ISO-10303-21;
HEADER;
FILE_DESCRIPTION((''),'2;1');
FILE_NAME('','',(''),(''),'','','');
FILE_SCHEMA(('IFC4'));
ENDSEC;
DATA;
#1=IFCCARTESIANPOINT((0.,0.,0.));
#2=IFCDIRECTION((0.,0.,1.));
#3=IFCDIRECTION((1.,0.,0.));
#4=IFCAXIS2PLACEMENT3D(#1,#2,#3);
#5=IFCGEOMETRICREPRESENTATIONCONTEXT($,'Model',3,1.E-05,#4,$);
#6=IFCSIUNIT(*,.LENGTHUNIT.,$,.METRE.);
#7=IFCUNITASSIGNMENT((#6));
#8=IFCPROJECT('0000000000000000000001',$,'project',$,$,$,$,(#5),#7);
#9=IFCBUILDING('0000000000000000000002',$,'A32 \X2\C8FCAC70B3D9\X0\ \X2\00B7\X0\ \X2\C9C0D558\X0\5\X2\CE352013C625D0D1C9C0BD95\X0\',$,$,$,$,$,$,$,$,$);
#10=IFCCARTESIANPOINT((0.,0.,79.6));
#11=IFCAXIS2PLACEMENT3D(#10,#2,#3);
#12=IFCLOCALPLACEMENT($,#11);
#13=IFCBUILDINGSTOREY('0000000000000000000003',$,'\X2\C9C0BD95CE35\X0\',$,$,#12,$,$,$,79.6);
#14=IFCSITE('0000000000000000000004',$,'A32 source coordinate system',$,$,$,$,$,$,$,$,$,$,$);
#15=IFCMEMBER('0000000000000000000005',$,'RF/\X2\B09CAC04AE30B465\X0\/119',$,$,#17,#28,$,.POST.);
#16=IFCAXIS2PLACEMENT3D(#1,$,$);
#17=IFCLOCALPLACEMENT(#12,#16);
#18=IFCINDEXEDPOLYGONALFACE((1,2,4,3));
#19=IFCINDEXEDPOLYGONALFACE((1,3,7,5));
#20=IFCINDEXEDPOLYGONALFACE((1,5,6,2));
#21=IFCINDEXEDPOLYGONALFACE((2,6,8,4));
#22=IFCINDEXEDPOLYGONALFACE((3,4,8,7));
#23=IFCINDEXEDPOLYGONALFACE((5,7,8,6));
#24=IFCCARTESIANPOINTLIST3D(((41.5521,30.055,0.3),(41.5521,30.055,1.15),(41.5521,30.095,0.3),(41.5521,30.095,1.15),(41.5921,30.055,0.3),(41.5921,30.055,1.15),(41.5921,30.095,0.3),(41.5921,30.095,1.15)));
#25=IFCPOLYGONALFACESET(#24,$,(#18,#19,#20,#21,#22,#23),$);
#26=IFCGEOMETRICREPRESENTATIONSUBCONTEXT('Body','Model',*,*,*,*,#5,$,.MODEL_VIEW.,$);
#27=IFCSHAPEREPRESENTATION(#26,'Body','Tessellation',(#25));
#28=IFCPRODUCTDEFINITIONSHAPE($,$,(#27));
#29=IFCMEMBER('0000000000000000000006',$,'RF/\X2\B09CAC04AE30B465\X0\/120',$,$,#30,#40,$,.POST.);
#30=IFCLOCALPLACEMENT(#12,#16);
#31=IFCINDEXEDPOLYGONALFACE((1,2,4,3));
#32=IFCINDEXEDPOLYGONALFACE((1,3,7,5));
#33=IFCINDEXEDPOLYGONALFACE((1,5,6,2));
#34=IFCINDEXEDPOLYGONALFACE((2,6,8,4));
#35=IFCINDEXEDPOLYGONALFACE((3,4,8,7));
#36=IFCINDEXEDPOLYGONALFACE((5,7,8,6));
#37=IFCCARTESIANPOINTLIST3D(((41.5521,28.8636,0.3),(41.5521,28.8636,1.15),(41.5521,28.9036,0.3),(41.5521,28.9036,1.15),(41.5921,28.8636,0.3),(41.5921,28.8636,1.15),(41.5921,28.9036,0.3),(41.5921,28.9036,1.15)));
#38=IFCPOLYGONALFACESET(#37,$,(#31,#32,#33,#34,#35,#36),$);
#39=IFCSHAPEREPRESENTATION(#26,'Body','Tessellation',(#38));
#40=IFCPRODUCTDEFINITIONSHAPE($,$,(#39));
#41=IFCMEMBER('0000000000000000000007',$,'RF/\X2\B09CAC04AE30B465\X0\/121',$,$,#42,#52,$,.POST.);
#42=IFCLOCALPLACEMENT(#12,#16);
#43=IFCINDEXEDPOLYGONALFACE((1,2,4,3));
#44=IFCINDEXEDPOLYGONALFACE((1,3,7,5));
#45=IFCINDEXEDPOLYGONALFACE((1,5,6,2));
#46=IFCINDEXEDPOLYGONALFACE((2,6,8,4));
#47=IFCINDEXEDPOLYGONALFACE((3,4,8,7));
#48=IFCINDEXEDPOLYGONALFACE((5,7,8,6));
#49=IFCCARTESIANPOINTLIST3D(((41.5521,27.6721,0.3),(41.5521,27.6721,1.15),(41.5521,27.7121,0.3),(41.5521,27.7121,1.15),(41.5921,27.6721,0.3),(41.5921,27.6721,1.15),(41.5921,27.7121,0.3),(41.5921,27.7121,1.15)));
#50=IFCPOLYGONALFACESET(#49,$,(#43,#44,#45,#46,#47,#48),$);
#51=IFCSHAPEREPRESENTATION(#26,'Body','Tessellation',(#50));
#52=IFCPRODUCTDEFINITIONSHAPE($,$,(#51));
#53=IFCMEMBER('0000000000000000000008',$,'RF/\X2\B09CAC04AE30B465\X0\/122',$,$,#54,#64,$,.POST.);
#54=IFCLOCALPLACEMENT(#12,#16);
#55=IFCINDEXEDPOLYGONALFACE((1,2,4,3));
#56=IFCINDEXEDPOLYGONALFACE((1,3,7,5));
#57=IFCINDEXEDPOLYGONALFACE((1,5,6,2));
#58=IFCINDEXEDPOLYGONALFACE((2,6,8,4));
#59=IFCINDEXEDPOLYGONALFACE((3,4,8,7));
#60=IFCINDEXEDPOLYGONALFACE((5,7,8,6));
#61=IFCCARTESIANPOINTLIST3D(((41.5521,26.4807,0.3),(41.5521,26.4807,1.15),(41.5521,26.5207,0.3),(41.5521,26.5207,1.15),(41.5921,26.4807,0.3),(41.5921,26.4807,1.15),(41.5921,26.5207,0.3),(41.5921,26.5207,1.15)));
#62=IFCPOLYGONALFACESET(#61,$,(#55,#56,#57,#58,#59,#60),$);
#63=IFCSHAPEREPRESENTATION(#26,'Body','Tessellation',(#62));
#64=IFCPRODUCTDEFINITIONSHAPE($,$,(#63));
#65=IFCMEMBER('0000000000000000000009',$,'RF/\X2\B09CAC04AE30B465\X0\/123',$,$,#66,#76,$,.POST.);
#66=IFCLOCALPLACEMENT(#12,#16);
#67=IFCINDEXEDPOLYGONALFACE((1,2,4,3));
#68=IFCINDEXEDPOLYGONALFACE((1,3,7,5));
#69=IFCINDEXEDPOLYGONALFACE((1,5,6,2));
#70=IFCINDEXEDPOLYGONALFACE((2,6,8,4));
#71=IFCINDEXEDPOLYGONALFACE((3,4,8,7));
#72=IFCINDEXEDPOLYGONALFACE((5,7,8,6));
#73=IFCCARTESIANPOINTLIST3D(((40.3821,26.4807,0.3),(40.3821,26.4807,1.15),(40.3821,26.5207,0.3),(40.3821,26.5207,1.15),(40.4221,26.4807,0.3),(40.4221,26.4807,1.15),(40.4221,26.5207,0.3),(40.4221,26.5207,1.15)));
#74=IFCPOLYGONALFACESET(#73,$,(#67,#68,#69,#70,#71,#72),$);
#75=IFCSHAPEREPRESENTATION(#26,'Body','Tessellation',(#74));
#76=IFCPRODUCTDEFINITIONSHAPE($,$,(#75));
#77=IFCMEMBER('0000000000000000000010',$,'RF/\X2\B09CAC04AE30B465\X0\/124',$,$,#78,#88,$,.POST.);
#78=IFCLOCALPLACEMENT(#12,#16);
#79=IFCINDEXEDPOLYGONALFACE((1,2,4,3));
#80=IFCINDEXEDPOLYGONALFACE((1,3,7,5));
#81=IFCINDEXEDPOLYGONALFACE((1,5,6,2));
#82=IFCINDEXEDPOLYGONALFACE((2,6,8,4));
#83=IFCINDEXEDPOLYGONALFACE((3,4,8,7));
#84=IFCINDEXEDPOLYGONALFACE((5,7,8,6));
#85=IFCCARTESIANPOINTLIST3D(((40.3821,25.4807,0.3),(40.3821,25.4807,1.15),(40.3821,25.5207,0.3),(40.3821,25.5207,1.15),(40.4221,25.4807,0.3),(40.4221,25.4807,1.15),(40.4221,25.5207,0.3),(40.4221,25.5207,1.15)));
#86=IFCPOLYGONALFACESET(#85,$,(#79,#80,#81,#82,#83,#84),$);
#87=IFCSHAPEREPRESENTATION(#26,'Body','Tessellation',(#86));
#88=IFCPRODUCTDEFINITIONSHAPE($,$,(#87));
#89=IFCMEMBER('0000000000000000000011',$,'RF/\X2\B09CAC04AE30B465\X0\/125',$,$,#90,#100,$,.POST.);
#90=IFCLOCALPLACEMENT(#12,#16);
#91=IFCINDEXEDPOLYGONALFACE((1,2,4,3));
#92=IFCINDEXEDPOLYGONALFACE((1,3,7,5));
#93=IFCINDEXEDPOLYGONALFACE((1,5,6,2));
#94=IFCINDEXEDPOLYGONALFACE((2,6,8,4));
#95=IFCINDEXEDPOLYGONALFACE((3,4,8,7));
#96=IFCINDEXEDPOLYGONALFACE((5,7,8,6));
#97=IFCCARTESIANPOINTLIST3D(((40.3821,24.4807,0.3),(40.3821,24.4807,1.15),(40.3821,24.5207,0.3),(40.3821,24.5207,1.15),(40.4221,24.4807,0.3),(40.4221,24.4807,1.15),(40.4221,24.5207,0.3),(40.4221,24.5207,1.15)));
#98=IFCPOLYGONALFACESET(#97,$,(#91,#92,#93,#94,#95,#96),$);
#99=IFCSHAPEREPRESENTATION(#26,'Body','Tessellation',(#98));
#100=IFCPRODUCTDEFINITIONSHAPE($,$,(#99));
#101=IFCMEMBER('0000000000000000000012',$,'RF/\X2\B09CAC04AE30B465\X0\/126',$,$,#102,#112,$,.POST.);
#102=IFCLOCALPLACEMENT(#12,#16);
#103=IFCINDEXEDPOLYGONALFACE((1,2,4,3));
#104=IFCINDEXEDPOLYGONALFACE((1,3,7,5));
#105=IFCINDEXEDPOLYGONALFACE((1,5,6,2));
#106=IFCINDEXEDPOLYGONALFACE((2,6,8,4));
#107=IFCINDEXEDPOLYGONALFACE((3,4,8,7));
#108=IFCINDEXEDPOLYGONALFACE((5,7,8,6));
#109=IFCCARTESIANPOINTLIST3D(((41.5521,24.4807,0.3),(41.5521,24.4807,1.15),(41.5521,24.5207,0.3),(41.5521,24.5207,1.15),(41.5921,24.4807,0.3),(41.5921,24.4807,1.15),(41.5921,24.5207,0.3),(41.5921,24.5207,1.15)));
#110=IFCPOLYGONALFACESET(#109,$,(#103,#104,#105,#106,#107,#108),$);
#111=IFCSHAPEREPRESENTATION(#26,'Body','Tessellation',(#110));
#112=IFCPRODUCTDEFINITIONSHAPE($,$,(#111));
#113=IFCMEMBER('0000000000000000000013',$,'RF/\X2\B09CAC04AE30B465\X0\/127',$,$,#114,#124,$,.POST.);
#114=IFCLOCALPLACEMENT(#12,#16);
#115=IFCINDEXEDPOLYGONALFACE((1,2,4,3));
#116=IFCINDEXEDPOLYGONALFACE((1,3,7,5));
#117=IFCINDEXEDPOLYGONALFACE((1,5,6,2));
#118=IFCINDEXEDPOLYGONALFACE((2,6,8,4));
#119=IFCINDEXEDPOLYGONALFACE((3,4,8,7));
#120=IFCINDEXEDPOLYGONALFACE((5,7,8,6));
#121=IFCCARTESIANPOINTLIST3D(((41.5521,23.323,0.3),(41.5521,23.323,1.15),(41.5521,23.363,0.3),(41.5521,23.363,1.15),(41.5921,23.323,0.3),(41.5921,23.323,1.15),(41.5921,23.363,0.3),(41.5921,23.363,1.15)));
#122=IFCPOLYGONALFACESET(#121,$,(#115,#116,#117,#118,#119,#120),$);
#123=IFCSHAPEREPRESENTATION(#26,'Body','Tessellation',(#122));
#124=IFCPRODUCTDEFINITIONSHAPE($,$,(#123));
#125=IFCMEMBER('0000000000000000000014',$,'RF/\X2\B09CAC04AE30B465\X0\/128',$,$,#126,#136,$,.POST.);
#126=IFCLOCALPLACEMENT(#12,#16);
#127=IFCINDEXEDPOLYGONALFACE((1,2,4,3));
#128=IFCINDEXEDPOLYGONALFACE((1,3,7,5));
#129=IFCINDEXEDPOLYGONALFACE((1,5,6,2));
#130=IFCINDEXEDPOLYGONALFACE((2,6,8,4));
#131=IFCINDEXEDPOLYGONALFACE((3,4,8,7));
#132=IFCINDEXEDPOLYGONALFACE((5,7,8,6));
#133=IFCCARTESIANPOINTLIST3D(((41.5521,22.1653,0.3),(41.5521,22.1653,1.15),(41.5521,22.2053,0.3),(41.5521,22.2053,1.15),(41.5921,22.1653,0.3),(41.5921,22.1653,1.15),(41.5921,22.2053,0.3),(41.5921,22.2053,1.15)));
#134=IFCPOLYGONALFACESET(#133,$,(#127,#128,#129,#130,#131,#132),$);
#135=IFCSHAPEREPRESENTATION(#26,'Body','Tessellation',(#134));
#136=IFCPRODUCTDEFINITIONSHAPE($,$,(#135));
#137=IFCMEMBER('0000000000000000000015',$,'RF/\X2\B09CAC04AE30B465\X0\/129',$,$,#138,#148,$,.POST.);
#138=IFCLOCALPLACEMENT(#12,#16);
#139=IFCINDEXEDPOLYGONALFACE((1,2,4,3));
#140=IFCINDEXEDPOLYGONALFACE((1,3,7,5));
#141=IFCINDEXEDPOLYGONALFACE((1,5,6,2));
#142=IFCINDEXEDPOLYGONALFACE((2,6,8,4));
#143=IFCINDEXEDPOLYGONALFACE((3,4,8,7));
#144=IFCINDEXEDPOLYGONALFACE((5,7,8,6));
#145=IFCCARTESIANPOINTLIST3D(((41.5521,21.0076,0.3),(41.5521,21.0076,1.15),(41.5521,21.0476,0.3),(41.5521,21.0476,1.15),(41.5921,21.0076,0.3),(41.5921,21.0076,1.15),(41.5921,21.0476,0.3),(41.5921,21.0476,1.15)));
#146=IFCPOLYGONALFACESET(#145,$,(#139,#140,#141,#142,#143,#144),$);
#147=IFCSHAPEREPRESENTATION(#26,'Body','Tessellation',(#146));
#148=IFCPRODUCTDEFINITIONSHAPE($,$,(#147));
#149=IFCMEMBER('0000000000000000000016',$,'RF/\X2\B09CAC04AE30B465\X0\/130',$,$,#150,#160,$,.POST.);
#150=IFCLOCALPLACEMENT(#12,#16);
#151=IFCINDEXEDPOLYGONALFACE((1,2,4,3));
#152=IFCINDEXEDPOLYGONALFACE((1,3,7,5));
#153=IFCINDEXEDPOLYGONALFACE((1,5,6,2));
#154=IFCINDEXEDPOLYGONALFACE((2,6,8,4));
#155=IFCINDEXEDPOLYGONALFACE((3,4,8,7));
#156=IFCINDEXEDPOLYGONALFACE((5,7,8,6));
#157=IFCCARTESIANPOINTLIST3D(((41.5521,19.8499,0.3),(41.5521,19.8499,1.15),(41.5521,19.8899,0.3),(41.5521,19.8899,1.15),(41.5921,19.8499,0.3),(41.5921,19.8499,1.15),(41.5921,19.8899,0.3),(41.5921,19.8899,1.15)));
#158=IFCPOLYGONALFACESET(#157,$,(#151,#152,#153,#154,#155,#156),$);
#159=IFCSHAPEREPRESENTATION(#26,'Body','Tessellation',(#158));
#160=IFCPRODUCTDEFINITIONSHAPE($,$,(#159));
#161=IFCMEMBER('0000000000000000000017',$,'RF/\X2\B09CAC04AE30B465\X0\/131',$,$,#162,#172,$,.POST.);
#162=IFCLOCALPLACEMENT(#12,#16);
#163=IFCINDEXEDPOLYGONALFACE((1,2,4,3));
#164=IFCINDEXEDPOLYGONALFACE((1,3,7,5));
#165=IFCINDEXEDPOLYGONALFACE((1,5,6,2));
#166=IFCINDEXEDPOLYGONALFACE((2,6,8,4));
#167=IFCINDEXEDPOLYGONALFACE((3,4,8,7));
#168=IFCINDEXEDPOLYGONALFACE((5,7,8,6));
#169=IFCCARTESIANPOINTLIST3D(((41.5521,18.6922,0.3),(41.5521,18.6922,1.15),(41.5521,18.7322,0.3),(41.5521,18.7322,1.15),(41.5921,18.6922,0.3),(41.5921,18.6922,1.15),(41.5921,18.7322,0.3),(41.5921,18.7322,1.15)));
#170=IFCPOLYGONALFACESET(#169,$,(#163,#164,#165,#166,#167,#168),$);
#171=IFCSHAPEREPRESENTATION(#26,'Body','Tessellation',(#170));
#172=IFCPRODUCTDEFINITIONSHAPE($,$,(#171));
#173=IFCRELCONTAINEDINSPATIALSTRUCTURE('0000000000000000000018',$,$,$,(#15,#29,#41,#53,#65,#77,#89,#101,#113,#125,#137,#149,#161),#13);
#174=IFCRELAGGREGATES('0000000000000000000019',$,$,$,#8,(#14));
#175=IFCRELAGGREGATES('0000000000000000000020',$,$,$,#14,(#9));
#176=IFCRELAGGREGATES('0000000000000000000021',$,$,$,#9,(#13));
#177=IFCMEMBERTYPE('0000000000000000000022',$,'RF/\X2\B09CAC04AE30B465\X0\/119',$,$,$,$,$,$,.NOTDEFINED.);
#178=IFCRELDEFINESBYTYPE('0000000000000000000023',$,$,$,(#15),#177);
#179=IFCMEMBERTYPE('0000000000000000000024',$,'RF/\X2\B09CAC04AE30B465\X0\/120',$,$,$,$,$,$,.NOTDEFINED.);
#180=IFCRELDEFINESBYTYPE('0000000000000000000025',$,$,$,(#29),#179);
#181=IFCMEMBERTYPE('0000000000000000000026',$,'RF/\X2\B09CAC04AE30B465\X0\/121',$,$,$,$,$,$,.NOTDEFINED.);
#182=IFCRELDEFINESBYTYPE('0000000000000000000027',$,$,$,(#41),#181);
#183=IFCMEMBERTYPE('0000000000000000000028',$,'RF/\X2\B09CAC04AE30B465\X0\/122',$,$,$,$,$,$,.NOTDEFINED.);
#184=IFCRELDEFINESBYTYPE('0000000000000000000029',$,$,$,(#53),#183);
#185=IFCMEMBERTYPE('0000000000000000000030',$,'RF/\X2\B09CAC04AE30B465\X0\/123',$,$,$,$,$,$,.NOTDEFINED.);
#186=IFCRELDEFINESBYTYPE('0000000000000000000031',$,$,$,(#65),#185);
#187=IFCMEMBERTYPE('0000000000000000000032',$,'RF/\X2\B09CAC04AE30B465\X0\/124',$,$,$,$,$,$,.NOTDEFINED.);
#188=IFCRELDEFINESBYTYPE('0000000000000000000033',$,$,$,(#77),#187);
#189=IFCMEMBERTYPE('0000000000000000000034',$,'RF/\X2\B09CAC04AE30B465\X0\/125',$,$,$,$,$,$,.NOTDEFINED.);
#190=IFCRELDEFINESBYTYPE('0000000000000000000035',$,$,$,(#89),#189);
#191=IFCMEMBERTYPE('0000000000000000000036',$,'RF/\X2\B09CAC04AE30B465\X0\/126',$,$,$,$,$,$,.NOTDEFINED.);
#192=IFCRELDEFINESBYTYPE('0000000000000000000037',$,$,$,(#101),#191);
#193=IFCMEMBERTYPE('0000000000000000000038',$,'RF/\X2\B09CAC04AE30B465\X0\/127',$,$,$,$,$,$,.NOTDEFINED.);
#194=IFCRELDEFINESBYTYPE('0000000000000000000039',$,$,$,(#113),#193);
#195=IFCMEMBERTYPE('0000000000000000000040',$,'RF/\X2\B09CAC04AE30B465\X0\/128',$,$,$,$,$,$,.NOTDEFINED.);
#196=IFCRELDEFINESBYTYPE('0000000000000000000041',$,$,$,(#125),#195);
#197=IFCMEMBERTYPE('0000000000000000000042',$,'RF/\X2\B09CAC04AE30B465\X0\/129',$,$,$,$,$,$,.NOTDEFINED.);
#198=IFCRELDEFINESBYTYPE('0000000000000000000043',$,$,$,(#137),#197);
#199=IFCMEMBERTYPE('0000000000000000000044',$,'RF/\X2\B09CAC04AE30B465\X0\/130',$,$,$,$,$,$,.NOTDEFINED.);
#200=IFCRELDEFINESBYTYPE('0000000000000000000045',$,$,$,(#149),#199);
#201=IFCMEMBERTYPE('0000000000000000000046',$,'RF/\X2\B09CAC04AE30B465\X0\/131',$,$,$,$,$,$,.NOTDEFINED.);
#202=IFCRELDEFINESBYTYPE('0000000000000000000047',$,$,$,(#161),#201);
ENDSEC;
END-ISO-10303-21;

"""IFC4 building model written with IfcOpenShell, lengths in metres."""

from ifc_helpers import new_model, si_unit, frame, origin, origin_with_axes, place, context, subcontext, project, spatial, polyline, outline, extrude, source, transform, mapped, type_object, type_shapes, element, save


model = new_model("IFC4")

# Units and contexts
model_context = context("Model", 3, precision=1e-05, world=origin_with_axes())
body_context = subcontext(model_context, "Body", "Model", "MODEL_VIEW")
ifc_project = project(units=[si_unit("LENGTHUNIT", "METRE")], contexts=[model_context])

# Site, building, storey
site = spatial("IfcSite", under=ifc_project, Name="A32 source coordinate system")
building = spatial("IfcBuilding", under=site, Name="A32 주거동 · 지하5층–옥탑지붕")
storey_placement = place(None, frame((0.0, 0.0, 79.6), z_axis=(0.0, 0.0, 1.0), x_axis=(1.0, 0.0, 0.0)))
storey = spatial("IfcBuildingStorey", under=building, at=storey_placement, Name="지붕층", Elevation=79.6)

# Members
member_type_1 = type_object("IfcMemberType", Name="RF/난간기둥/119", PredefinedType="NOTDEFINED")
shared_shape_1 = source(origin(), body_context, "Body", "SweptSolid", [
    extrude(outline(polyline([(41.5921, 30.055), (41.5521, 30.055), (41.5521, 30.095), (41.5921, 30.095), (41.5921, 30.055)])), frame((0.0, 0.0, 0.3)), (0.0, 0.0, 1.0), 0.85),
])
type_shapes(member_type_1, [shared_shape_1])
member_1_placement = place(storey_placement, origin_with_axes())
element("IfcMember", 1, at=member_1_placement, inside=storey, type_object=member_type_1, Name="RF/난간기둥/119", PredefinedType="POST", context=body_context, shape_type="MappedRepresentation", body=[
    mapped(shared_shape_1, transform((0.0, 0.0, 0.0), scale=1.0)),
])
member_type_2 = type_object("IfcMemberType", Name="RF/난간기둥/120", PredefinedType="NOTDEFINED")
shared_shape_2 = source(origin(), body_context, "Body", "SweptSolid", [
    extrude(outline(polyline([(41.5921, 28.8636), (41.5521, 28.8636), (41.5521, 28.9036), (41.5921, 28.9036), (41.5921, 28.8636)])), frame((0.0, 0.0, 0.3)), (0.0, 0.0, 1.0), 0.85),
])
type_shapes(member_type_2, [shared_shape_2])
member_2_placement = place(storey_placement, origin_with_axes())
element("IfcMember", 2, at=member_2_placement, inside=storey, type_object=member_type_2, Name="RF/난간기둥/120", PredefinedType="POST", context=body_context, shape_type="MappedRepresentation", body=[
    mapped(shared_shape_2, transform((0.0, 0.0, 0.0), scale=1.0)),
])
member_type_3 = type_object("IfcMemberType", Name="RF/난간기둥/121", PredefinedType="NOTDEFINED")
shared_shape_3 = source(origin(), body_context, "Body", "SweptSolid", [
    extrude(outline(polyline([(41.5921, 27.6721), (41.5521, 27.6721), (41.5521, 27.7121), (41.5921, 27.7121), (41.5921, 27.6721)])), frame((0.0, 0.0, 0.3)), (0.0, 0.0, 1.0), 0.85),
])
type_shapes(member_type_3, [shared_shape_3])
member_3_placement = place(storey_placement, origin_with_axes())
element("IfcMember", 3, at=member_3_placement, inside=storey, type_object=member_type_3, Name="RF/난간기둥/121", PredefinedType="POST", context=body_context, shape_type="MappedRepresentation", body=[
    mapped(shared_shape_3, transform((0.0, 0.0, 0.0), scale=1.0)),
])
member_type_4 = type_object("IfcMemberType", Name="RF/난간기둥/122", PredefinedType="NOTDEFINED")
shared_shape_4 = source(origin(), body_context, "Body", "SweptSolid", [
    extrude(outline(polyline([(41.5921, 26.4807), (41.5521, 26.4807), (41.5521, 26.5207), (41.5921, 26.5207), (41.5921, 26.4807)])), frame((0.0, 0.0, 0.3)), (0.0, 0.0, 1.0), 0.85),
])
type_shapes(member_type_4, [shared_shape_4])
member_4_placement = place(storey_placement, origin_with_axes())
element("IfcMember", 4, at=member_4_placement, inside=storey, type_object=member_type_4, Name="RF/난간기둥/122", PredefinedType="POST", context=body_context, shape_type="MappedRepresentation", body=[
    mapped(shared_shape_4, transform((0.0, 0.0, 0.0), scale=1.0)),
])
member_type_5 = type_object("IfcMemberType", Name="RF/난간기둥/123", PredefinedType="NOTDEFINED")
shared_shape_5 = source(origin(), body_context, "Body", "SweptSolid", [
    extrude(outline(polyline([(40.4221, 26.4807), (40.3821, 26.4807), (40.3821, 26.5207), (40.4221, 26.5207), (40.4221, 26.4807)])), frame((0.0, 0.0, 0.3)), (0.0, 0.0, 1.0), 0.85),
])
type_shapes(member_type_5, [shared_shape_5])
member_5_placement = place(storey_placement, origin_with_axes())
element("IfcMember", 5, at=member_5_placement, inside=storey, type_object=member_type_5, Name="RF/난간기둥/123", PredefinedType="POST", context=body_context, shape_type="MappedRepresentation", body=[
    mapped(shared_shape_5, transform((0.0, 0.0, 0.0), scale=1.0)),
])
member_type_6 = type_object("IfcMemberType", Name="RF/난간기둥/124", PredefinedType="NOTDEFINED")
shared_shape_6 = source(origin(), body_context, "Body", "SweptSolid", [
    extrude(outline(polyline([(40.4221, 25.4807), (40.3821, 25.4807), (40.3821, 25.5207), (40.4221, 25.5207), (40.4221, 25.4807)])), frame((0.0, 0.0, 0.3)), (0.0, 0.0, 1.0), 0.85),
])
type_shapes(member_type_6, [shared_shape_6])
member_6_placement = place(storey_placement, origin_with_axes())
element("IfcMember", 6, at=member_6_placement, inside=storey, type_object=member_type_6, Name="RF/난간기둥/124", PredefinedType="POST", context=body_context, shape_type="MappedRepresentation", body=[
    mapped(shared_shape_6, transform((0.0, 0.0, 0.0), scale=1.0)),
])
member_type_7 = type_object("IfcMemberType", Name="RF/난간기둥/125", PredefinedType="NOTDEFINED")
shared_shape_7 = source(origin(), body_context, "Body", "SweptSolid", [
    extrude(outline(polyline([(40.4221, 24.4807), (40.3821, 24.4807), (40.3821, 24.5207), (40.4221, 24.5207), (40.4221, 24.4807)])), frame((0.0, 0.0, 0.3)), (0.0, 0.0, 1.0), 0.85),
])
type_shapes(member_type_7, [shared_shape_7])
member_7_placement = place(storey_placement, origin_with_axes())
element("IfcMember", 7, at=member_7_placement, inside=storey, type_object=member_type_7, Name="RF/난간기둥/125", PredefinedType="POST", context=body_context, shape_type="MappedRepresentation", body=[
    mapped(shared_shape_7, transform((0.0, 0.0, 0.0), scale=1.0)),
])
member_type_8 = type_object("IfcMemberType", Name="RF/난간기둥/126", PredefinedType="NOTDEFINED")
shared_shape_8 = source(origin(), body_context, "Body", "SweptSolid", [
    extrude(outline(polyline([(41.5921, 24.4807), (41.5521, 24.4807), (41.5521, 24.5207), (41.5921, 24.5207), (41.5921, 24.4807)])), frame((0.0, 0.0, 0.3)), (0.0, 0.0, 1.0), 0.85),
])
type_shapes(member_type_8, [shared_shape_8])
member_8_placement = place(storey_placement, origin_with_axes())
element("IfcMember", 8, at=member_8_placement, inside=storey, type_object=member_type_8, Name="RF/난간기둥/126", PredefinedType="POST", context=body_context, shape_type="MappedRepresentation", body=[
    mapped(shared_shape_8, transform((0.0, 0.0, 0.0), scale=1.0)),
])
member_type_9 = type_object("IfcMemberType", Name="RF/난간기둥/127", PredefinedType="NOTDEFINED")
shared_shape_9 = source(origin(), body_context, "Body", "SweptSolid", [
    extrude(outline(polyline([(41.5921, 23.323), (41.5521, 23.323), (41.5521, 23.363), (41.5921, 23.363), (41.5921, 23.323)])), frame((0.0, 0.0, 0.3)), (0.0, 0.0, 1.0), 0.85),
])
type_shapes(member_type_9, [shared_shape_9])
member_9_placement = place(storey_placement, origin_with_axes())
element("IfcMember", 9, at=member_9_placement, inside=storey, type_object=member_type_9, Name="RF/난간기둥/127", PredefinedType="POST", context=body_context, shape_type="MappedRepresentation", body=[
    mapped(shared_shape_9, transform((0.0, 0.0, 0.0), scale=1.0)),
])
member_type_10 = type_object("IfcMemberType", Name="RF/난간기둥/128", PredefinedType="NOTDEFINED")
shared_shape_10 = source(origin(), body_context, "Body", "SweptSolid", [
    extrude(outline(polyline([(41.5921, 22.1653), (41.5521, 22.1653), (41.5521, 22.2053), (41.5921, 22.2053), (41.5921, 22.1653)])), frame((0.0, 0.0, 0.3)), (0.0, 0.0, 1.0), 0.85),
])
type_shapes(member_type_10, [shared_shape_10])
member_10_placement = place(storey_placement, origin_with_axes())
element("IfcMember", 10, at=member_10_placement, inside=storey, type_object=member_type_10, Name="RF/난간기둥/128", PredefinedType="POST", context=body_context, shape_type="MappedRepresentation", body=[
    mapped(shared_shape_10, transform((0.0, 0.0, 0.0), scale=1.0)),
])
member_type_11 = type_object("IfcMemberType", Name="RF/난간기둥/129", PredefinedType="NOTDEFINED")
shared_shape_11 = source(origin(), body_context, "Body", "SweptSolid", [
    extrude(outline(polyline([(41.5921, 21.0076), (41.5521, 21.0076), (41.5521, 21.0476), (41.5921, 21.0476), (41.5921, 21.0076)])), frame((0.0, 0.0, 0.3)), (0.0, 0.0, 1.0), 0.85),
])
type_shapes(member_type_11, [shared_shape_11])
member_11_placement = place(storey_placement, origin_with_axes())
element("IfcMember", 11, at=member_11_placement, inside=storey, type_object=member_type_11, Name="RF/난간기둥/129", PredefinedType="POST", context=body_context, shape_type="MappedRepresentation", body=[
    mapped(shared_shape_11, transform((0.0, 0.0, 0.0), scale=1.0)),
])
member_type_12 = type_object("IfcMemberType", Name="RF/난간기둥/130", PredefinedType="NOTDEFINED")
shared_shape_12 = source(origin(), body_context, "Body", "SweptSolid", [
    extrude(outline(polyline([(41.5921, 19.8499), (41.5521, 19.8499), (41.5521, 19.8899), (41.5921, 19.8899), (41.5921, 19.8499)])), frame((0.0, 0.0, 0.3)), (0.0, 0.0, 1.0), 0.85),
])
type_shapes(member_type_12, [shared_shape_12])
member_12_placement = place(storey_placement, origin_with_axes())
element("IfcMember", 12, at=member_12_placement, inside=storey, type_object=member_type_12, Name="RF/난간기둥/130", PredefinedType="POST", context=body_context, shape_type="MappedRepresentation", body=[
    mapped(shared_shape_12, transform((0.0, 0.0, 0.0), scale=1.0)),
])
member_type_13 = type_object("IfcMemberType", Name="RF/난간기둥/131", PredefinedType="NOTDEFINED")
shared_shape_13 = source(origin(), body_context, "Body", "SweptSolid", [
    extrude(outline(polyline([(41.5921, 18.6922), (41.5521, 18.6922), (41.5521, 18.7322), (41.5921, 18.7322), (41.5921, 18.6922)])), frame((0.0, 0.0, 0.3)), (0.0, 0.0, 1.0), 0.85),
])
type_shapes(member_type_13, [shared_shape_13])
member_13_placement = place(storey_placement, origin_with_axes())
element("IfcMember", 13, at=member_13_placement, inside=storey, type_object=member_type_13, Name="RF/난간기둥/131", PredefinedType="POST", context=body_context, shape_type="MappedRepresentation", body=[
    mapped(shared_shape_13, transform((0.0, 0.0, 0.0), scale=1.0)),
])

save(model, "model.ifc")
